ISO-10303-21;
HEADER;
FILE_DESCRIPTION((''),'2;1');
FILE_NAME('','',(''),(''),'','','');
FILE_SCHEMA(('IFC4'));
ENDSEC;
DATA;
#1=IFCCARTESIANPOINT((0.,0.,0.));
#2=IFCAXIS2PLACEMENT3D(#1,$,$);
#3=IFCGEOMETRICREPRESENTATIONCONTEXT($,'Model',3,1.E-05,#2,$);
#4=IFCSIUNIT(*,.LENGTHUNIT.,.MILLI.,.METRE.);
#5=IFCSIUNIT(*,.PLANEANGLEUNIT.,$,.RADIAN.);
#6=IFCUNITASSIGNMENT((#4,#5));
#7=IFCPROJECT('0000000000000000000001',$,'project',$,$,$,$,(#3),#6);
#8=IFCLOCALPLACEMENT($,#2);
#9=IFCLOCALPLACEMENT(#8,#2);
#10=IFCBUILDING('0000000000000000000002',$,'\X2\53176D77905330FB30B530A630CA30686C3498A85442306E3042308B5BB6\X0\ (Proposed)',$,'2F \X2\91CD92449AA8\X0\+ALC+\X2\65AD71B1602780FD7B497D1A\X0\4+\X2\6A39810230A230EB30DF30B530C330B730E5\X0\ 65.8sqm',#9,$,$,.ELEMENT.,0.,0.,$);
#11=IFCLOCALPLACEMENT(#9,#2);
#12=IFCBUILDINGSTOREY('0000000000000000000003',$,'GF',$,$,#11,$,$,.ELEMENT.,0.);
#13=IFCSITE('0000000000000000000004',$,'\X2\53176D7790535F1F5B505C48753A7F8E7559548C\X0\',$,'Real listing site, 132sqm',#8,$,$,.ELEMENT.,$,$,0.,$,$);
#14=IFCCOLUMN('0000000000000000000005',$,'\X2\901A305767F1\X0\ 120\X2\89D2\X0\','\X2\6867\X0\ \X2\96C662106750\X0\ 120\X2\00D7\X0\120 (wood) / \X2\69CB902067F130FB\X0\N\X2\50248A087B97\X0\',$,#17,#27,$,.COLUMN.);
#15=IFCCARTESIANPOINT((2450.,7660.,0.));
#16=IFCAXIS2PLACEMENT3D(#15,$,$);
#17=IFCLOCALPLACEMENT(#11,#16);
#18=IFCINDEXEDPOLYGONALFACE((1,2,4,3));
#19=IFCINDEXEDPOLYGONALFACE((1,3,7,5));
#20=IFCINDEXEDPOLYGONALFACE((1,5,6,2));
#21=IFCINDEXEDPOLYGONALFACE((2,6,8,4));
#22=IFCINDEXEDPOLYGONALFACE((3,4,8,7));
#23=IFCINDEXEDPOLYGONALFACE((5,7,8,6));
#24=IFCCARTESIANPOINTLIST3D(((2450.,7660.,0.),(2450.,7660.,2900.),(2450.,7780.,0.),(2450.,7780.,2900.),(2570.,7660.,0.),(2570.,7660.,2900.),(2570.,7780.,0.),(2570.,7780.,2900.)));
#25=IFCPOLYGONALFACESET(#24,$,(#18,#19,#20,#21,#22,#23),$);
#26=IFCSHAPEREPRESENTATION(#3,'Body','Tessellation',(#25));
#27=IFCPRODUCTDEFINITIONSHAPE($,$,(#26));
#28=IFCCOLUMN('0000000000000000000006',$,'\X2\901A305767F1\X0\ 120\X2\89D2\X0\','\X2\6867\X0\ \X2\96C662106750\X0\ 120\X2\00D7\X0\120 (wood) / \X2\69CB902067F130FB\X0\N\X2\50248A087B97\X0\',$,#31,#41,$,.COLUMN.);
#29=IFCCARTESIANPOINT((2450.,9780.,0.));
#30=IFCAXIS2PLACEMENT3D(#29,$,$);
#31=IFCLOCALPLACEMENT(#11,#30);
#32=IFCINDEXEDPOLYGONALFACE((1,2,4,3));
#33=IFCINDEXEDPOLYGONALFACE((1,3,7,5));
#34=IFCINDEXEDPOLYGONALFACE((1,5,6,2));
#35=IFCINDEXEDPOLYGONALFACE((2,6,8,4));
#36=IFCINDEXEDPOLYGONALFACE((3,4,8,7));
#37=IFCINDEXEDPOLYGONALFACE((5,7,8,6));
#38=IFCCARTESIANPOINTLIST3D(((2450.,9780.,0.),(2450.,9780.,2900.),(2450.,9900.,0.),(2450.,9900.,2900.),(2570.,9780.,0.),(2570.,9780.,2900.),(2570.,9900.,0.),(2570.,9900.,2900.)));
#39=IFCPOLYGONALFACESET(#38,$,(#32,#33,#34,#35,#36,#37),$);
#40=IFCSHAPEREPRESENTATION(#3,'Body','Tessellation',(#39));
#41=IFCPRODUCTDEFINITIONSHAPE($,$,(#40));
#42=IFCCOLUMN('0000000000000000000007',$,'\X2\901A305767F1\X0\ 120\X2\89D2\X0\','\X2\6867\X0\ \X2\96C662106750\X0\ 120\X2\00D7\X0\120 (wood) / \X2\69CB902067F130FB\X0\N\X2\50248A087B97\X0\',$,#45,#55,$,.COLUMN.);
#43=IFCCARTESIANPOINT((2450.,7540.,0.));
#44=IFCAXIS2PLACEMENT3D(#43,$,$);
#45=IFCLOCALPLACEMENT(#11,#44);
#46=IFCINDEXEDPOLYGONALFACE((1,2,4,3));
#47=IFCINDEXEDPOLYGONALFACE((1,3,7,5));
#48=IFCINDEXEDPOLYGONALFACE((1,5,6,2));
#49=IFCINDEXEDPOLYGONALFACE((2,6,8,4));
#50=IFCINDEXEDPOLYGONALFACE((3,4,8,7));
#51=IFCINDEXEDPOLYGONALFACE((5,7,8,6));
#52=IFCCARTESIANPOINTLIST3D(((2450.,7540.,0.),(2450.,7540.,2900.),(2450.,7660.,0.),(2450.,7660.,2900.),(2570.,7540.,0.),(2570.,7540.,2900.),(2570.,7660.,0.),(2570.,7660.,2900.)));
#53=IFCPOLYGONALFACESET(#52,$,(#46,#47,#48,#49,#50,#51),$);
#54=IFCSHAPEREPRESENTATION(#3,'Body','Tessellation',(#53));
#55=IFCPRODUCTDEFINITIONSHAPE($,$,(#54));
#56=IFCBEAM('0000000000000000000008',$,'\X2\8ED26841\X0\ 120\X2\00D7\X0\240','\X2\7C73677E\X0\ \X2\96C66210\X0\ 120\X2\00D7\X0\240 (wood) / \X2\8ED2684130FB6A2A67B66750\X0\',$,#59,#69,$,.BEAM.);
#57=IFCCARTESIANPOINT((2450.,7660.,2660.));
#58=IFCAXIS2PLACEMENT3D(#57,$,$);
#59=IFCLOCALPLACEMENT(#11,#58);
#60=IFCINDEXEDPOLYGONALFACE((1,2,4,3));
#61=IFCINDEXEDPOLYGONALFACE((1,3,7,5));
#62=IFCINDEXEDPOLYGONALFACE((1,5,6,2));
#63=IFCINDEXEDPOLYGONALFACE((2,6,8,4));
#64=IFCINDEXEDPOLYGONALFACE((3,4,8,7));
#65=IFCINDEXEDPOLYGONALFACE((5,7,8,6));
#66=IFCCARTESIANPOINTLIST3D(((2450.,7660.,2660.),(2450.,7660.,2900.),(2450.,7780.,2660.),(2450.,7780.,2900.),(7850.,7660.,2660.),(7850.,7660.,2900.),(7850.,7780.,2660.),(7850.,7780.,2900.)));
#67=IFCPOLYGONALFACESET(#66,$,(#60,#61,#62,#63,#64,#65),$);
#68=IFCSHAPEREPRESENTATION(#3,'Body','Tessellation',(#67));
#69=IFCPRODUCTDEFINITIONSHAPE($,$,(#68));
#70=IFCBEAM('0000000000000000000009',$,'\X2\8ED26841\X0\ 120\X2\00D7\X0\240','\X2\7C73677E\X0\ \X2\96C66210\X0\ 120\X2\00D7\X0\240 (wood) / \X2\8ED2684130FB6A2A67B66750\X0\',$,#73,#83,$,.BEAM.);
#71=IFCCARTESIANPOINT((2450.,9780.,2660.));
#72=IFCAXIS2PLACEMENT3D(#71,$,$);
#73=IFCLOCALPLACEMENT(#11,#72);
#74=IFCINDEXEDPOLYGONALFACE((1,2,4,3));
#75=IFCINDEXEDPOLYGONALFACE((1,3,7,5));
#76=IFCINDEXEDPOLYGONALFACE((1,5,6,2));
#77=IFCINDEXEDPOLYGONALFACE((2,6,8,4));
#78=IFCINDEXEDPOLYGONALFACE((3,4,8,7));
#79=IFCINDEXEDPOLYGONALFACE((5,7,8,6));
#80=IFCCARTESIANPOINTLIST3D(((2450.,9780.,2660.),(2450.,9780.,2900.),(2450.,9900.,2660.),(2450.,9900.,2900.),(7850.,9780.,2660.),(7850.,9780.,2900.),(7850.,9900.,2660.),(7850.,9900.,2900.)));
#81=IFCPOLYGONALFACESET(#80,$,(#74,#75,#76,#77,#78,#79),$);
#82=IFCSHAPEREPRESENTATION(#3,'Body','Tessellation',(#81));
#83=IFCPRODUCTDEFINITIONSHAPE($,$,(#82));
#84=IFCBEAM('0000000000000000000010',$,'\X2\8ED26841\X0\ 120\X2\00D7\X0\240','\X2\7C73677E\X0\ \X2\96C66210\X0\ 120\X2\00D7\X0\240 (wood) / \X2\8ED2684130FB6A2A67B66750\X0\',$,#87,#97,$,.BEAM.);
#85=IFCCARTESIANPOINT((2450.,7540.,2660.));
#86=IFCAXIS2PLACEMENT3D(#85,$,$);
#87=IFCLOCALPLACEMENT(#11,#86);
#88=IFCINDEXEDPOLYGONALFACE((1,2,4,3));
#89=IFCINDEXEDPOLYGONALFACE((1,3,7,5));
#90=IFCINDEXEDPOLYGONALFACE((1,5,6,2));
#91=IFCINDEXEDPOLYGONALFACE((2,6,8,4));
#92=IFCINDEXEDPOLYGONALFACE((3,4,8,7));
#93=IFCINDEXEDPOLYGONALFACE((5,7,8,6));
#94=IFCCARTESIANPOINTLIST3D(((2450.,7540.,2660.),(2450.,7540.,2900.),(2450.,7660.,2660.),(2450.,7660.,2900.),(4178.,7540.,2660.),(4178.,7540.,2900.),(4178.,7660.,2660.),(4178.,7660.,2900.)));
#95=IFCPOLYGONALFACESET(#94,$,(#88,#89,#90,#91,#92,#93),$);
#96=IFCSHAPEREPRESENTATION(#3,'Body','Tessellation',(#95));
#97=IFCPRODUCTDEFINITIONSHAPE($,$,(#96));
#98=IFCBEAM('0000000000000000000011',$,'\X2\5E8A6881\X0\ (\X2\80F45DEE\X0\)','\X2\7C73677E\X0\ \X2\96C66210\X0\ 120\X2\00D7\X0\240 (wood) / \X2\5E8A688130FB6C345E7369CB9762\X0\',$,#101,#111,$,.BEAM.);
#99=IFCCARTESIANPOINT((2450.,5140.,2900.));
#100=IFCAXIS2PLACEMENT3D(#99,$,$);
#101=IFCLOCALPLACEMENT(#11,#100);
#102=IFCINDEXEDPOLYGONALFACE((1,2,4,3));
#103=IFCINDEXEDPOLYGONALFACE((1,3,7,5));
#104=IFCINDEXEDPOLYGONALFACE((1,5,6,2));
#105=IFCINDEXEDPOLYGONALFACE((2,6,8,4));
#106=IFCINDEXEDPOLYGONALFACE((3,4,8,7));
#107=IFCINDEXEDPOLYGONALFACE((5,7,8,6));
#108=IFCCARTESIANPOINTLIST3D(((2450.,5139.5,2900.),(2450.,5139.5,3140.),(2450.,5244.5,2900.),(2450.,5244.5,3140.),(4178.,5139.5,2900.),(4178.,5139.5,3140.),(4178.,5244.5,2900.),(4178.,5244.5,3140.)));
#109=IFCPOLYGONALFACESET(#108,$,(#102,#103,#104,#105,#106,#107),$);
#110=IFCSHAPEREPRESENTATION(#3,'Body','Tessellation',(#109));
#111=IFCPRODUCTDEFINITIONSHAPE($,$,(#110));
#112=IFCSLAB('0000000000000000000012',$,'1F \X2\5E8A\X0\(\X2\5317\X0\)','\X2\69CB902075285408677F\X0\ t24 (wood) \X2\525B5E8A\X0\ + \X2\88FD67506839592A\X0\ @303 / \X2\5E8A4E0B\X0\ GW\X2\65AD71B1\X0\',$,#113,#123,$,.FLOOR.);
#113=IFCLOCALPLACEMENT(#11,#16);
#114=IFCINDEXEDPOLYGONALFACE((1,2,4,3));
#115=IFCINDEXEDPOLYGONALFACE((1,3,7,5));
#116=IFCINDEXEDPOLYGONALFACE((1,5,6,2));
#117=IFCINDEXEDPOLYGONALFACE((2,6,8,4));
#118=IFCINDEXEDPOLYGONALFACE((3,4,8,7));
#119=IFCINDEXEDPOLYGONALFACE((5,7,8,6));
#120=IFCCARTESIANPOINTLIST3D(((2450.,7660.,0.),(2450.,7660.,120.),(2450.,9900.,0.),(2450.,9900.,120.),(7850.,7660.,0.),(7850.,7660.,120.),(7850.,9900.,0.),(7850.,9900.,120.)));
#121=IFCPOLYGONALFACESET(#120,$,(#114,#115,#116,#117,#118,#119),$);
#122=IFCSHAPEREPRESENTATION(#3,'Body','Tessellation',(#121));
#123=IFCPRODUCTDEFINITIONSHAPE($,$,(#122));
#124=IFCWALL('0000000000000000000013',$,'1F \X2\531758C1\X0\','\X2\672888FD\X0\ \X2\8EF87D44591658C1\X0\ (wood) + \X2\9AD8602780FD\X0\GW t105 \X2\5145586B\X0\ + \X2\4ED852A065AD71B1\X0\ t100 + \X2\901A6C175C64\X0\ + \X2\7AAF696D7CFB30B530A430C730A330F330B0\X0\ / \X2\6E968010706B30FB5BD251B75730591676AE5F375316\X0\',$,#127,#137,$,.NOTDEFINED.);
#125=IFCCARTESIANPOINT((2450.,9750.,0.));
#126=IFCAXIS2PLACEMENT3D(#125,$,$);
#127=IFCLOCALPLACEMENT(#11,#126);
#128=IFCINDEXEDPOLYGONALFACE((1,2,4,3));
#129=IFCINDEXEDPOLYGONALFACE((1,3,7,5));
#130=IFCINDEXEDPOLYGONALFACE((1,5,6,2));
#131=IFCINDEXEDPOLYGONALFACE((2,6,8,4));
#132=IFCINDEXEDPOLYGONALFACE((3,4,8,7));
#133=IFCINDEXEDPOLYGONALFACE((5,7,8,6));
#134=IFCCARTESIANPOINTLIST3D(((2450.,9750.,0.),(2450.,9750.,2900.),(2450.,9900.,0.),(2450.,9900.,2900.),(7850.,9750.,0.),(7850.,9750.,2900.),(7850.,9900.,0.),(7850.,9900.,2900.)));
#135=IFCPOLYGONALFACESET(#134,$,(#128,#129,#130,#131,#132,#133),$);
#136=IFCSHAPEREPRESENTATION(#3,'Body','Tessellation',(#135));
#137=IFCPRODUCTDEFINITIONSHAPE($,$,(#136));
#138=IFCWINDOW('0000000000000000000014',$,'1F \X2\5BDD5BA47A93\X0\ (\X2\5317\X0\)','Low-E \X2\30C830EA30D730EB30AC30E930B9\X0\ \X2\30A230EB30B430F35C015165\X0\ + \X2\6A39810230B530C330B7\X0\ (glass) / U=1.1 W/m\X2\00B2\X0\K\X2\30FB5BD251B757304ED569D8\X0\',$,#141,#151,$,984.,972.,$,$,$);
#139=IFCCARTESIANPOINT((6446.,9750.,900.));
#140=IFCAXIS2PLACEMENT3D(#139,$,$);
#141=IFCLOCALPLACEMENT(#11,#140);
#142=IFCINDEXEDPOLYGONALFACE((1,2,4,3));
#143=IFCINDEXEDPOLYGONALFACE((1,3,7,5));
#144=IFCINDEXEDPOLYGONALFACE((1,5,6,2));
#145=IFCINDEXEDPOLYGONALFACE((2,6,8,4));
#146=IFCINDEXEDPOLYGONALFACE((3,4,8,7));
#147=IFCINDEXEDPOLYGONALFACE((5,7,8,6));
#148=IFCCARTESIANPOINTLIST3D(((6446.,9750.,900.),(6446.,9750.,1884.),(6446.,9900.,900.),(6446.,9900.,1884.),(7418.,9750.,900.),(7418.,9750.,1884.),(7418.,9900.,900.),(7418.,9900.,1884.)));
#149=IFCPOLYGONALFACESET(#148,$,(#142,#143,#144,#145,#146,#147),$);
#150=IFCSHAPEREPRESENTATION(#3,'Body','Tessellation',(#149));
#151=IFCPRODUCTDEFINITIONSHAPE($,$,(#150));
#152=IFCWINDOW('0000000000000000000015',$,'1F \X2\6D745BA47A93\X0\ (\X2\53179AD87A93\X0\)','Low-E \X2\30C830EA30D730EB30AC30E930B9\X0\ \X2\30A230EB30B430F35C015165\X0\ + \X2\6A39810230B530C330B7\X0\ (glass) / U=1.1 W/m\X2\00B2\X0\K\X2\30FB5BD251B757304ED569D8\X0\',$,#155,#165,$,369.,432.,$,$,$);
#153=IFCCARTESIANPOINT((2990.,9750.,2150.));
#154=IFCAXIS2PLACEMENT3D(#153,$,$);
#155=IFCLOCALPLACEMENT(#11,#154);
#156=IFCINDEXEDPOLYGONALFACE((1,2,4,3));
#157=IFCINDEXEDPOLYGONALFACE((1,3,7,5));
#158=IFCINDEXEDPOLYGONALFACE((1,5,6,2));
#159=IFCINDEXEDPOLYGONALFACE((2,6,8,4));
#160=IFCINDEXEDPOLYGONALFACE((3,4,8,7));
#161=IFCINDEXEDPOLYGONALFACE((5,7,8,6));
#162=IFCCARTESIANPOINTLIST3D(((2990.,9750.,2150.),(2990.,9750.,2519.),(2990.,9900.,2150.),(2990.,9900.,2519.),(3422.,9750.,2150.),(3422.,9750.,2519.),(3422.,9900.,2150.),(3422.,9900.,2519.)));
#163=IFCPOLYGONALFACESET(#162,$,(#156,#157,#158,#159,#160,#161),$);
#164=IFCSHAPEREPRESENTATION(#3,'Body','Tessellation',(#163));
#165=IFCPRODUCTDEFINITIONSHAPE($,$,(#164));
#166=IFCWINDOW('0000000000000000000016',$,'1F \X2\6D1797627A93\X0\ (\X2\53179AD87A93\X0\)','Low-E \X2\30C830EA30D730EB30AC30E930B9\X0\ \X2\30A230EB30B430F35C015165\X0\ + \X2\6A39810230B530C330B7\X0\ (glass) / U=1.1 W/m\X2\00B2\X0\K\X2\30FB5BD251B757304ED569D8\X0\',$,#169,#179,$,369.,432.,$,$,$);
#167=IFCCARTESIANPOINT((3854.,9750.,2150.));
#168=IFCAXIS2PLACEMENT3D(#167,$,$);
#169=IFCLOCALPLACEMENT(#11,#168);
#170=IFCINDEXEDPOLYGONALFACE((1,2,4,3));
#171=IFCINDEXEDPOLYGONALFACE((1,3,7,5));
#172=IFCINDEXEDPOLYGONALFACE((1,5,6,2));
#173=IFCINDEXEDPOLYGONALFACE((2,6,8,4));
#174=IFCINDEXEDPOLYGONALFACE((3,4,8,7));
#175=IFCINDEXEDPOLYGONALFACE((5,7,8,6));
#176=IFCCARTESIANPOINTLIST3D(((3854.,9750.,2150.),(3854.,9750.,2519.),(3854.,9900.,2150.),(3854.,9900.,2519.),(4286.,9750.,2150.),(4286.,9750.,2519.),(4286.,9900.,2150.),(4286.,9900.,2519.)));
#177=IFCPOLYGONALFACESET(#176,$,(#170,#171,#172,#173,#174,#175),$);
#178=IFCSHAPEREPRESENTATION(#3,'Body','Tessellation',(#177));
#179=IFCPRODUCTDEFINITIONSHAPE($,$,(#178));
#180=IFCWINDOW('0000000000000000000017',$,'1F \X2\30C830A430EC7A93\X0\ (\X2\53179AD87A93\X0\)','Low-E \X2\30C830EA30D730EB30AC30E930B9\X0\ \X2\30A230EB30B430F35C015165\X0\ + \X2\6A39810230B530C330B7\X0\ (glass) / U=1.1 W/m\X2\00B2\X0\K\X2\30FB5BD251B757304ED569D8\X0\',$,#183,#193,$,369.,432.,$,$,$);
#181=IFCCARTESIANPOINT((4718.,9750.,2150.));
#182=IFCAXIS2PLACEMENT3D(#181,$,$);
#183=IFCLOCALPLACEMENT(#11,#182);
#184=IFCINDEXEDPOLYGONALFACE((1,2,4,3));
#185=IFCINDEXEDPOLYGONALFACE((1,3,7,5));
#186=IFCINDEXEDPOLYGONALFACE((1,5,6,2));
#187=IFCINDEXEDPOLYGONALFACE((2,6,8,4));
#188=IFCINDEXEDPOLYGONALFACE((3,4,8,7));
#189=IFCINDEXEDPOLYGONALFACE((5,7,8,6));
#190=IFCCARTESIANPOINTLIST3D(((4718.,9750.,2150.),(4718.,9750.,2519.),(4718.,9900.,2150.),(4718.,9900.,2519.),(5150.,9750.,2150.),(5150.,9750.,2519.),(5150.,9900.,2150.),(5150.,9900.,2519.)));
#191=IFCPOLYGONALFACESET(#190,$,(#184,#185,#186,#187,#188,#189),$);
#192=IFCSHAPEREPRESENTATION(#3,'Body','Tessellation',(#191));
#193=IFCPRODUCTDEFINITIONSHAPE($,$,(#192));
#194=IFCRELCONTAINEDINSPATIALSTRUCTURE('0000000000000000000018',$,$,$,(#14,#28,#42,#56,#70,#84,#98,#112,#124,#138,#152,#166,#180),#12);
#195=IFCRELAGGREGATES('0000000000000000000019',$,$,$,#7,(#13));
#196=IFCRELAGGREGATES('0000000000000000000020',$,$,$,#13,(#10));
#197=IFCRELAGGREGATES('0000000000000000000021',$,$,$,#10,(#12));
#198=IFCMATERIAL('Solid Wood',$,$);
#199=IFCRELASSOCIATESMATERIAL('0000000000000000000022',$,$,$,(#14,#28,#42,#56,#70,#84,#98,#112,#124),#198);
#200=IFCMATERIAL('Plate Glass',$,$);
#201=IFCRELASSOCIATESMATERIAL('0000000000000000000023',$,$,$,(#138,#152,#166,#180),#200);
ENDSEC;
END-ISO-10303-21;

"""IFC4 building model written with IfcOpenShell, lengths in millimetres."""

from ifc_helpers import new_model, si_unit, frame, frame_2d, origin, place, context, project, spatial, rectangle, extrude, material, element, fill, save


model = new_model("IFC4")

# Units and contexts
model_context = context("Model", 3, precision=1e-05, world=origin())
ifc_project = project(units=[si_unit("LENGTHUNIT", "METRE", prefix="MILLI"), si_unit("PLANEANGLEUNIT", "RADIAN")], contexts=[model_context])

# Site, building, storey
site_placement = place(None, origin())
site = spatial("IfcSite", under=ifc_project, at=site_placement, Name="北海道弟子屈町美留和", ObjectType="Real listing site, 132sqm", CompositionType="ELEMENT", RefElevation=0.0)
building_placement = place(site_placement, origin())
building = spatial("IfcBuilding", under=site, at=building_placement, Name="北海道・サウナと水風呂のある家 (Proposed)", ObjectType="2F 重鉄骨+ALC+断熱性能等級4+樹脂アルミサッシュ 65.8sqm", CompositionType="ELEMENT", ElevationOfRefHeight=0.0, ElevationOfTerrain=0.0)
storey_placement = place(building_placement, origin())
storey = spatial("IfcBuildingStorey", under=building, at=storey_placement, Name="GF", CompositionType="ELEMENT", Elevation=0.0)

# Columns
ifc_material_1 = material(Name="Solid Wood")
column_1_placement = place(storey_placement, frame((2450.0, 7660.0, 0.0)))
element("IfcColumn", 1, at=column_1_placement, inside=storey, material=ifc_material_1, Name="通し柱 120角", Description="桧 集成材 120×120 (wood) / 構造柱・N値計算", PredefinedType="COLUMN", context=model_context, shape_type="SweptSolid", body=[
    extrude(rectangle(XDim=120.0, YDim=120.0, at=frame_2d((60.0, 60.0))), frame((2450.0, 7660.0, 0.0)), (0.0, 0.0, 1.0), 2900.0),
])
column_2_placement = place(storey_placement, frame((2450.0, 9780.0, 0.0)))
element("IfcColumn", 2, at=column_2_placement, inside=storey, material=ifc_material_1, Name="通し柱 120角", Description="桧 集成材 120×120 (wood) / 構造柱・N値計算", PredefinedType="COLUMN", context=model_context, shape_type="SweptSolid", body=[
    extrude(rectangle(XDim=120.0, YDim=120.0, at=frame_2d((60.0, 60.0))), frame((2450.0, 9780.0, 0.0)), (0.0, 0.0, 1.0), 2900.0),
])
column_3_placement = place(storey_placement, frame((2450.0, 7540.0, 0.0)))
element("IfcColumn", 3, at=column_3_placement, inside=storey, material=ifc_material_1, Name="通し柱 120角", Description="桧 集成材 120×120 (wood) / 構造柱・N値計算", PredefinedType="COLUMN", context=model_context, shape_type="SweptSolid", body=[
    extrude(rectangle(XDim=120.0, YDim=120.0, at=frame_2d((60.0, 60.0))), frame((2450.0, 7540.0, 0.0)), (0.0, 0.0, 1.0), 2900.0),
])

# Beams
beam_1_placement = place(storey_placement, frame((2450.0, 7660.0, 2660.0)))
element("IfcBeam", 4, at=beam_1_placement, inside=storey, material=ifc_material_1, Name="軒桁 120×240", Description="米松 集成 120×240 (wood) / 軒桁・横架材", PredefinedType="BEAM", context=model_context, shape_type="SweptSolid", body=[
    extrude(rectangle(XDim=5400.0, YDim=120.0, at=frame_2d((2700.0, 60.0))), frame((2450.0, 7660.0, 2660.0)), (0.0, 0.0, 1.0), 240.0),
])
beam_2_placement = place(storey_placement, frame((2450.0, 9780.0, 2660.0)))
element("IfcBeam", 5, at=beam_2_placement, inside=storey, material=ifc_material_1, Name="軒桁 120×240", Description="米松 集成 120×240 (wood) / 軒桁・横架材", PredefinedType="BEAM", context=model_context, shape_type="SweptSolid", body=[
    extrude(rectangle(XDim=5400.0, YDim=120.0, at=frame_2d((2700.0, 60.0))), frame((2450.0, 9780.0, 2660.0)), (0.0, 0.0, 1.0), 240.0),
])
beam_3_placement = place(storey_placement, frame((2450.0, 7540.0, 2660.0)))
element("IfcBeam", 6, at=beam_3_placement, inside=storey, material=ifc_material_1, Name="軒桁 120×240", Description="米松 集成 120×240 (wood) / 軒桁・横架材", PredefinedType="BEAM", context=model_context, shape_type="SweptSolid", body=[
    extrude(rectangle(XDim=1728.0, YDim=120.0, at=frame_2d((864.0, 60.0))), frame((2450.0, 7540.0, 2660.0)), (0.0, 0.0, 1.0), 240.0),
])
beam_4_placement = place(storey_placement, frame((2450.0, 5140.0, 2900.0)))
element("IfcBeam", 7, at=beam_4_placement, inside=storey, material=ifc_material_1, Name="床梁 (胴差)", Description="米松 集成 120×240 (wood) / 床梁・水平構面", PredefinedType="BEAM", context=model_context, shape_type="SweptSolid", body=[
    extrude(rectangle(XDim=1728.0, YDim=105.0, at=frame_2d((864.0, 52.0))), frame((2450.0, 5140.0, 2900.0)), (0.0, 0.0, 1.0), 240.0),
])

# Slab
slab_placement = place(storey_placement, frame((2450.0, 7660.0, 0.0)))
element("IfcSlab", 8, at=slab_placement, inside=storey, material=ifc_material_1, Name="1F 床(北)", Description="構造用合板 t24 (wood) 剛床 + 製材根太 @303 / 床下 GW断熱", PredefinedType="FLOOR", context=model_context, shape_type="SweptSolid", body=[
    extrude(rectangle(XDim=5400.0, YDim=2240.0, at=frame_2d((2700.0, 1120.0))), frame((2450.0, 7660.0, 0.0)), (0.0, 0.0, 1.0), 120.0),
])

# Wall, openings, windows
wall_1_placement = place(storey_placement, frame((2450.0, 9750.0, 0.0)))
wall_1 = element("IfcWall", 9, at=wall_1_placement, inside=storey, material=ifc_material_1, Name="1F 北壁", Description="木製 軸組外壁 (wood) + 高性能GW t105 充填 + 付加断熱 t100 + 通気層 + 窯業系サイディング / 準耐火・寒冷地外皮強化", PredefinedType="NOTDEFINED", context=model_context, shape_type="SweptSolid", body=[
    extrude(rectangle(XDim=5400.0, YDim=150.0, at=frame_2d((2700.0, 75.0))), frame((2450.0, 9750.0, 0.0)), (0.0, 0.0, 1.0), 2900.0),
])
opening_1_placement = place(storey_placement, frame((6446.0, 9750.0, 900.0)))
opening_1 = element("IfcOpeningElement", 10, at=opening_1_placement, cuts=wall_1, PredefinedType="NOTDEFINED", context=model_context, shape_type="SweptSolid", body=[
    extrude(rectangle(XDim=972.0, YDim=150.0, at=frame_2d((486.0, 75.0))), frame((6446.0, 9750.0, 900.0)), (0.0, 0.0, 1.0), 984.0),
])
opening_2_placement = place(storey_placement, frame((2990.0, 9750.0, 2150.0)))
opening_2 = element("IfcOpeningElement", 11, at=opening_2_placement, cuts=wall_1, PredefinedType="NOTDEFINED", context=model_context, shape_type="SweptSolid", body=[
    extrude(rectangle(XDim=432.0, YDim=150.0, at=frame_2d((216.0, 75.0))), frame((2990.0, 9750.0, 2150.0)), (0.0, 0.0, 1.0), 369.0),
])
opening_3_placement = place(storey_placement, frame((3854.0, 9750.0, 2150.0)))
opening_3 = element("IfcOpeningElement", 12, at=opening_3_placement, cuts=wall_1, PredefinedType="NOTDEFINED", context=model_context, shape_type="SweptSolid", body=[
    extrude(rectangle(XDim=432.0, YDim=150.0, at=frame_2d((216.0, 75.0))), frame((3854.0, 9750.0, 2150.0)), (0.0, 0.0, 1.0), 369.0),
])
opening_4_placement = place(storey_placement, frame((4718.0, 9750.0, 2150.0)))
opening_4 = element("IfcOpeningElement", 13, at=opening_4_placement, cuts=wall_1, PredefinedType="NOTDEFINED", context=model_context, shape_type="SweptSolid", body=[
    extrude(rectangle(XDim=432.0, YDim=150.0, at=frame_2d((216.0, 75.0))), frame((4718.0, 9750.0, 2150.0)), (0.0, 0.0, 1.0), 369.0),
])
ifc_material_2 = material(Name="Plate Glass")
window_1_placement = place(storey_placement, frame((6446.0, 9750.0, 900.0)))
window_1 = element("IfcWindow", 14, at=window_1_placement, inside=storey, material=ifc_material_2, Name="1F 寝室窓 (北)", Description="Low-E トリプルガラス アルゴン封入 + 樹脂サッシ (glass) / U=1.1 W/m²K・寒冷地仕様", OverallHeight=984.0, OverallWidth=972.0, context=model_context, shape_type="SweptSolid", body=[
    extrude(rectangle(XDim=972.0, YDim=150.0, at=frame_2d((486.0, 75.0))), frame((6446.0, 9750.0, 900.0)), (0.0, 0.0, 1.0), 984.0),
])
fill(opening_1, window_1)
window_2_placement = place(storey_placement, frame((2990.0, 9750.0, 2150.0)))
window_2 = element("IfcWindow", 15, at=window_2_placement, inside=storey, material=ifc_material_2, Name="1F 浴室窓 (北高窓)", Description="Low-E トリプルガラス アルゴン封入 + 樹脂サッシ (glass) / U=1.1 W/m²K・寒冷地仕様", OverallHeight=369.0, OverallWidth=432.0, context=model_context, shape_type="SweptSolid", body=[
    extrude(rectangle(XDim=432.0, YDim=150.0, at=frame_2d((216.0, 75.0))), frame((2990.0, 9750.0, 2150.0)), (0.0, 0.0, 1.0), 369.0),
])
fill(opening_2, window_2)
window_3_placement = place(storey_placement, frame((3854.0, 9750.0, 2150.0)))
window_3 = element("IfcWindow", 16, at=window_3_placement, inside=storey, material=ifc_material_2, Name="1F 洗面窓 (北高窓)", Description="Low-E トリプルガラス アルゴン封入 + 樹脂サッシ (glass) / U=1.1 W/m²K・寒冷地仕様", OverallHeight=369.0, OverallWidth=432.0, context=model_context, shape_type="SweptSolid", body=[
    extrude(rectangle(XDim=432.0, YDim=150.0, at=frame_2d((216.0, 75.0))), frame((3854.0, 9750.0, 2150.0)), (0.0, 0.0, 1.0), 369.0),
])
fill(opening_3, window_3)
window_4_placement = place(storey_placement, frame((4718.0, 9750.0, 2150.0)))
window_4 = element("IfcWindow", 17, at=window_4_placement, inside=storey, material=ifc_material_2, Name="1F トイレ窓 (北高窓)", Description="Low-E トリプルガラス アルゴン封入 + 樹脂サッシ (glass) / U=1.1 W/m²K・寒冷地仕様", OverallHeight=369.0, OverallWidth=432.0, context=model_context, shape_type="SweptSolid", body=[
    extrude(rectangle(XDim=432.0, YDim=150.0, at=frame_2d((216.0, 75.0))), frame((4718.0, 9750.0, 2150.0)), (0.0, 0.0, 1.0), 369.0),
])
fill(opening_4, window_4)

save(model, "model.ifc")
